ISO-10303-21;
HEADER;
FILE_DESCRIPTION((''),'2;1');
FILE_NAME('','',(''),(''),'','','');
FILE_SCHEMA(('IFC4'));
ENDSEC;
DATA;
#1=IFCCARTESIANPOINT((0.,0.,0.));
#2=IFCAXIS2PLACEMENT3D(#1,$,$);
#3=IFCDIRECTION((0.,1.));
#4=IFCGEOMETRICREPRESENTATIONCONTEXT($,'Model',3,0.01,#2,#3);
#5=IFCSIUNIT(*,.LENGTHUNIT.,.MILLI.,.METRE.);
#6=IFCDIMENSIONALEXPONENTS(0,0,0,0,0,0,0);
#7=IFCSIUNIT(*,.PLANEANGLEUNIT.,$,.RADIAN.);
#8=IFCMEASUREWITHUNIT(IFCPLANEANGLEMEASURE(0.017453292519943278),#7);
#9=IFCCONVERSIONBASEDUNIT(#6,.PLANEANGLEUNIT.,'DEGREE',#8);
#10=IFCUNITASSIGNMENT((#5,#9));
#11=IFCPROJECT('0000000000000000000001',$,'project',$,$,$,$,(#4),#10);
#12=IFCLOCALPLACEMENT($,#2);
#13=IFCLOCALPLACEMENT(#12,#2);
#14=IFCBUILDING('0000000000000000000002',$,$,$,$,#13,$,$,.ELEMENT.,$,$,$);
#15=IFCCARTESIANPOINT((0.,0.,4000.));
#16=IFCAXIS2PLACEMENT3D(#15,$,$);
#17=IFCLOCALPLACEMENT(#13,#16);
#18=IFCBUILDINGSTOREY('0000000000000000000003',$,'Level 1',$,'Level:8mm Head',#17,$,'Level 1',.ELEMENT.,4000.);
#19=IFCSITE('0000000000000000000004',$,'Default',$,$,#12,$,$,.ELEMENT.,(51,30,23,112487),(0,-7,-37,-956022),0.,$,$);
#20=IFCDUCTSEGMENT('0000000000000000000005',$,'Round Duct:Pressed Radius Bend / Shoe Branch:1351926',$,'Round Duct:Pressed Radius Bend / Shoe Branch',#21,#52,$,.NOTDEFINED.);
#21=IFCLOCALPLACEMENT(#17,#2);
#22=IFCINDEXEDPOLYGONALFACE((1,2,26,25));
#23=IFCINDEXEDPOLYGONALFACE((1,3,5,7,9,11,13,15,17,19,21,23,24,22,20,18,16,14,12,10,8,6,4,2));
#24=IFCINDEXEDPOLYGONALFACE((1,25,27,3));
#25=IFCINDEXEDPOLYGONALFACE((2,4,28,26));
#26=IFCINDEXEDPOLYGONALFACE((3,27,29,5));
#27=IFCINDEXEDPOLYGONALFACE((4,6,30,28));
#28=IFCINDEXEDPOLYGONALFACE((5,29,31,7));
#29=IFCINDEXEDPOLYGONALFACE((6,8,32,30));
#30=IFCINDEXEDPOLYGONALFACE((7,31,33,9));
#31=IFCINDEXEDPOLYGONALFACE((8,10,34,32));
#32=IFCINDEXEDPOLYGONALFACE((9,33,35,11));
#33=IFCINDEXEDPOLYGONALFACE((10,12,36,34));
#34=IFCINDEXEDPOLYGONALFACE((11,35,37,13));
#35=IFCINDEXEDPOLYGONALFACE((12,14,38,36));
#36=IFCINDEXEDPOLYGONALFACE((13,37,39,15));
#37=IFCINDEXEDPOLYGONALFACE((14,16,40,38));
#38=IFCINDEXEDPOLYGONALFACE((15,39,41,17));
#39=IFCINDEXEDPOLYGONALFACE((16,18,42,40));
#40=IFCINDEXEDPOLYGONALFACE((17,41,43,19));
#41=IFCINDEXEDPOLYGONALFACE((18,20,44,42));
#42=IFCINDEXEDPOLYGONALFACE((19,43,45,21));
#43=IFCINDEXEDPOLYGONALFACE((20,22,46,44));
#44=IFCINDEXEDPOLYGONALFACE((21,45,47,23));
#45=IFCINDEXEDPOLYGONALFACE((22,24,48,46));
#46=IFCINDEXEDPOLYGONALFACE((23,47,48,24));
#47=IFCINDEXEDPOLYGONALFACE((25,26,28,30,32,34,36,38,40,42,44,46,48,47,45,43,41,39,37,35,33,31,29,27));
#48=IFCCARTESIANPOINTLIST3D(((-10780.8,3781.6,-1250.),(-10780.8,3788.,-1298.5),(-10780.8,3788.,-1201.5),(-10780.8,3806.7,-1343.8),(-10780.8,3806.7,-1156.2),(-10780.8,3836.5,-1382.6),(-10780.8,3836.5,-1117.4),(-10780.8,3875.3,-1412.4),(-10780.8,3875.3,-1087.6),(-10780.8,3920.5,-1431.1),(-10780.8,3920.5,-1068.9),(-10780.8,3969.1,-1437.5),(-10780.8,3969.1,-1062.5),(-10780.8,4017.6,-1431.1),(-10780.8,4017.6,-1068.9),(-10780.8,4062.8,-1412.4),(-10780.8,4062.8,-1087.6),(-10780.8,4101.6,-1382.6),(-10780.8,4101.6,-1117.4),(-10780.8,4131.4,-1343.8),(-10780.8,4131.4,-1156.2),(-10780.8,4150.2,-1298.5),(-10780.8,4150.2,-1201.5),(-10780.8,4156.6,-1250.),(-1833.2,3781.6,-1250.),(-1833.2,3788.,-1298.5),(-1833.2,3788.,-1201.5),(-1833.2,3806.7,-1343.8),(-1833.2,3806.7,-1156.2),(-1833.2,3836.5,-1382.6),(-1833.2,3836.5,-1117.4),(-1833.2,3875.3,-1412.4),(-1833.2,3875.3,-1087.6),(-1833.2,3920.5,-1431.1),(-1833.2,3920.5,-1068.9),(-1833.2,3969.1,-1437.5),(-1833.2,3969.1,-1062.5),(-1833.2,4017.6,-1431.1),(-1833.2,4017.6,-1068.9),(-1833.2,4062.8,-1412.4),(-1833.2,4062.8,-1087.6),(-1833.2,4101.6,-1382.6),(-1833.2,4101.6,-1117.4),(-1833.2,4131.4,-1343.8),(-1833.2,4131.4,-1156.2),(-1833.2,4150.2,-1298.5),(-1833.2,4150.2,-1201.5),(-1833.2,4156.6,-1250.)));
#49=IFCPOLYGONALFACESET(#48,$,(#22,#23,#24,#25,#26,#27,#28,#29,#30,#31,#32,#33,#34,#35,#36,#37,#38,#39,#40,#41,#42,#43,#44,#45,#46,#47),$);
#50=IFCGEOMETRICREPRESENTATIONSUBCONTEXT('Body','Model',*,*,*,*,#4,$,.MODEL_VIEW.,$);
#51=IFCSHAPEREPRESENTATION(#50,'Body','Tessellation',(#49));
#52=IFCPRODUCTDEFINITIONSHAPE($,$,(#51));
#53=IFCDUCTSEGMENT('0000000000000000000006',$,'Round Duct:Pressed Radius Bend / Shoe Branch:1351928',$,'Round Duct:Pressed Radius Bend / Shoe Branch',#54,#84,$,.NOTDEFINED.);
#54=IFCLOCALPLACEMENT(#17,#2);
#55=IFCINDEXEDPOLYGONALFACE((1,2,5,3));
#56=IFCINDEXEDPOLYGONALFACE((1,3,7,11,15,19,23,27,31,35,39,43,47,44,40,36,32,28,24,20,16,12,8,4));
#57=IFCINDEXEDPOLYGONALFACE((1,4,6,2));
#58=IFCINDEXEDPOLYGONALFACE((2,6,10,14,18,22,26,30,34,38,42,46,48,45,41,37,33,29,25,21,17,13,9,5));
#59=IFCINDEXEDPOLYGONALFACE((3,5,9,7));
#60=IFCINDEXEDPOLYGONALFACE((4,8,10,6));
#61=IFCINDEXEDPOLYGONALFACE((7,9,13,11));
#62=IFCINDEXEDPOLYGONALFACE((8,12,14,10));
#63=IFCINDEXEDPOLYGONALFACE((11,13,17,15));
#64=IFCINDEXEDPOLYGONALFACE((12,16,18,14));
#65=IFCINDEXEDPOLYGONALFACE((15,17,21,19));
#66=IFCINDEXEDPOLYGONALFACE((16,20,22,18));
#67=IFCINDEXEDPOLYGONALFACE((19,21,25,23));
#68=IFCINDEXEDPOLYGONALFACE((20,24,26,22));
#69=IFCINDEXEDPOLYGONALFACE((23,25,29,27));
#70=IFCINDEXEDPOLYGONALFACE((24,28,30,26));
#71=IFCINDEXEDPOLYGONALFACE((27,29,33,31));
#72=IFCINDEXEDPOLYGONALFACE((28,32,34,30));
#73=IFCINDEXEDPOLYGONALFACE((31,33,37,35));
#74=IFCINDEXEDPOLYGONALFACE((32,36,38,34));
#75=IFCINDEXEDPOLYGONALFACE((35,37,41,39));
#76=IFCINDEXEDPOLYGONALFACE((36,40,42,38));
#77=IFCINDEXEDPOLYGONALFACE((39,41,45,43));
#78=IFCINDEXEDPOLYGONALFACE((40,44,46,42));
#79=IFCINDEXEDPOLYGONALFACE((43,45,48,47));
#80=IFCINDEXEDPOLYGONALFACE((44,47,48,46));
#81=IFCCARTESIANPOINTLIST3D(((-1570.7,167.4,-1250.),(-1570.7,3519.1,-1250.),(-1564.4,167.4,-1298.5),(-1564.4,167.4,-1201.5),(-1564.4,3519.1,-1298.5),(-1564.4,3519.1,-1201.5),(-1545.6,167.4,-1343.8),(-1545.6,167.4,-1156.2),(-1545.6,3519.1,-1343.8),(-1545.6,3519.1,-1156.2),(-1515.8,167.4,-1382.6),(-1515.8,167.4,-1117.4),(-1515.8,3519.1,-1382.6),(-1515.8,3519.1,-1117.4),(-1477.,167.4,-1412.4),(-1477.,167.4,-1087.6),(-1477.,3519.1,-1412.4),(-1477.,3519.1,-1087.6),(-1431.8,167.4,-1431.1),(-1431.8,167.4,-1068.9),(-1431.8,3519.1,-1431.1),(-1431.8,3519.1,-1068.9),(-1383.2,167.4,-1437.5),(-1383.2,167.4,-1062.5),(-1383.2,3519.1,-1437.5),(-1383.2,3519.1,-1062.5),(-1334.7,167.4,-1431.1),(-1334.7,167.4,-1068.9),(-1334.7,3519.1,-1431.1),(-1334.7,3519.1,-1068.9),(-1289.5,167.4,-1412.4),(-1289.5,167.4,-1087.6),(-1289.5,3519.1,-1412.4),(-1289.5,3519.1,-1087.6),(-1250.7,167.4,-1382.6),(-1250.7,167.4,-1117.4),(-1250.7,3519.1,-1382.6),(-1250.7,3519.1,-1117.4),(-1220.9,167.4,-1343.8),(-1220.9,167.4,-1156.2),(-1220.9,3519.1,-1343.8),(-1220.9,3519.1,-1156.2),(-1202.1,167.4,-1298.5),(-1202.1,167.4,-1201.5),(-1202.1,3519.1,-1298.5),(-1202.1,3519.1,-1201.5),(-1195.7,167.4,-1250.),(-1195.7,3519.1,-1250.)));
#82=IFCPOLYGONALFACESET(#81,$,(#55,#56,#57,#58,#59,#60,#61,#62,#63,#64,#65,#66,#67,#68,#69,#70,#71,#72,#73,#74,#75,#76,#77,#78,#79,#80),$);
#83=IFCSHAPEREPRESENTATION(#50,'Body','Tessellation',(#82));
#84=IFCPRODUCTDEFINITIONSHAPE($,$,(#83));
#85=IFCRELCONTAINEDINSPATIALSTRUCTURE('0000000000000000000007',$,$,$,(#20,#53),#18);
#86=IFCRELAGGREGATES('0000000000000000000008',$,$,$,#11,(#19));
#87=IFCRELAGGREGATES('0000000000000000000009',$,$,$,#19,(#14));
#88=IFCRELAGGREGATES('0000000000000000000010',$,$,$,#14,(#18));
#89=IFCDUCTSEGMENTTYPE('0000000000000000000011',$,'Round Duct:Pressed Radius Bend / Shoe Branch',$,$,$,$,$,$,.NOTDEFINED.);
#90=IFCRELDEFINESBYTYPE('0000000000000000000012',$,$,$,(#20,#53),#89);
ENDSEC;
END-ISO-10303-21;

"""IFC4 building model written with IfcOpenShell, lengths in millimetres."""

from ifc_helpers import new_model, entity, si_unit, converted_unit, direction, frame, origin, place, context, subcontext, project, spatial, arc, indexed_curve, outline, extrude, type_object, element, save


model = new_model("IFC4")

# Units and contexts
model_context = context("Model", 3, precision=0.01, world=origin(), true_north=direction((0.0, 1.0)))
body_context = subcontext(model_context, "Body", "Model", "MODEL_VIEW")
ifc_project = project(units=[si_unit("LENGTHUNIT", "METRE", prefix="MILLI"), converted_unit("PLANEANGLEUNIT", "DEGREE", entity("IfcPlaneAngleMeasure", 0.017453292519943278), si_unit("PLANEANGLEUNIT", "RADIAN"), dimensions=[0, 0, 0, 0, 0, 0, 0])], contexts=[model_context])

# Site, building, storey
site_placement = place(None, origin())
site = spatial("IfcSite", under=ifc_project, at=site_placement, Name="Default", CompositionType="ELEMENT", RefLatitude=(51, 30, 23, 112487), RefLongitude=(0, -7, -37, -956022), RefElevation=0.0)
building_placement = place(site_placement, origin())
building = spatial("IfcBuilding", under=site, at=building_placement, CompositionType="ELEMENT")
storey_placement = place(building_placement, frame((0.0, 0.0, 4000.0)))
storey = spatial("IfcBuildingStorey", under=building, at=storey_placement, Name="Level 1", ObjectType="Level:8mm Head", LongName="Level 1", CompositionType="ELEMENT", Elevation=4000.0)

# Duct segments
duct_segment_type = type_object("IfcDuctSegmentType", Name="Round Duct:Pressed Radius Bend / Shoe Branch", PredefinedType="NOTDEFINED")
duct_segment_1_placement = place(storey_placement, origin())
element("IfcDuctSegment", 1, at=duct_segment_1_placement, inside=storey, type_object=duct_segment_type, Name="Round Duct:Pressed Radius Bend / Shoe Branch:1351926", ObjectType="Round Duct:Pressed Radius Bend / Shoe Branch", PredefinedType="NOTDEFINED", context=body_context, shape_type="SweptSolid", body=[
    extrude(outline(indexed_curve([(187.5, 0.0), (132.6, 132.6), (0.0, 187.5), (-132.6, 132.6), (-187.5, 0.0), (-132.6, -132.6), (0.0, -187.5), (132.6, -132.6)], segments=[arc(1, 2, 3), arc(3, 4, 5), arc(5, 6, 7), arc(7, 8, 1)], self_intersect=False)), frame((-10780.8, 3969.1, -1250.0), z_axis=(1.0, 0.0, 0.0), x_axis=(0.0, -1.0, 0.0)), (0.0, 0.0, 1.0), 8947.6),
])
duct_segment_2_placement = place(storey_placement, origin())
element("IfcDuctSegment", 2, at=duct_segment_2_placement, inside=storey, type_object=duct_segment_type, Name="Round Duct:Pressed Radius Bend / Shoe Branch:1351928", ObjectType="Round Duct:Pressed Radius Bend / Shoe Branch", PredefinedType="NOTDEFINED", context=body_context, shape_type="SweptSolid", body=[
    extrude(outline(indexed_curve([(187.5, 0.0), (132.6, 132.6), (0.0, 187.5), (-132.6, 132.6), (-187.5, 0.0), (-132.6, -132.6), (0.0, -187.5), (132.6, -132.6)], segments=[arc(1, 2, 3), arc(3, 4, 5), arc(5, 6, 7), arc(7, 8, 1)], self_intersect=False)), frame((-1383.2, 167.4, -1250.0), z_axis=(0.0, 1.0, 0.0), x_axis=(1.0, 0.0, 0.0)), (0.0, 0.0, 1.0), 3351.7),
])

save(model, "model.ifc")
